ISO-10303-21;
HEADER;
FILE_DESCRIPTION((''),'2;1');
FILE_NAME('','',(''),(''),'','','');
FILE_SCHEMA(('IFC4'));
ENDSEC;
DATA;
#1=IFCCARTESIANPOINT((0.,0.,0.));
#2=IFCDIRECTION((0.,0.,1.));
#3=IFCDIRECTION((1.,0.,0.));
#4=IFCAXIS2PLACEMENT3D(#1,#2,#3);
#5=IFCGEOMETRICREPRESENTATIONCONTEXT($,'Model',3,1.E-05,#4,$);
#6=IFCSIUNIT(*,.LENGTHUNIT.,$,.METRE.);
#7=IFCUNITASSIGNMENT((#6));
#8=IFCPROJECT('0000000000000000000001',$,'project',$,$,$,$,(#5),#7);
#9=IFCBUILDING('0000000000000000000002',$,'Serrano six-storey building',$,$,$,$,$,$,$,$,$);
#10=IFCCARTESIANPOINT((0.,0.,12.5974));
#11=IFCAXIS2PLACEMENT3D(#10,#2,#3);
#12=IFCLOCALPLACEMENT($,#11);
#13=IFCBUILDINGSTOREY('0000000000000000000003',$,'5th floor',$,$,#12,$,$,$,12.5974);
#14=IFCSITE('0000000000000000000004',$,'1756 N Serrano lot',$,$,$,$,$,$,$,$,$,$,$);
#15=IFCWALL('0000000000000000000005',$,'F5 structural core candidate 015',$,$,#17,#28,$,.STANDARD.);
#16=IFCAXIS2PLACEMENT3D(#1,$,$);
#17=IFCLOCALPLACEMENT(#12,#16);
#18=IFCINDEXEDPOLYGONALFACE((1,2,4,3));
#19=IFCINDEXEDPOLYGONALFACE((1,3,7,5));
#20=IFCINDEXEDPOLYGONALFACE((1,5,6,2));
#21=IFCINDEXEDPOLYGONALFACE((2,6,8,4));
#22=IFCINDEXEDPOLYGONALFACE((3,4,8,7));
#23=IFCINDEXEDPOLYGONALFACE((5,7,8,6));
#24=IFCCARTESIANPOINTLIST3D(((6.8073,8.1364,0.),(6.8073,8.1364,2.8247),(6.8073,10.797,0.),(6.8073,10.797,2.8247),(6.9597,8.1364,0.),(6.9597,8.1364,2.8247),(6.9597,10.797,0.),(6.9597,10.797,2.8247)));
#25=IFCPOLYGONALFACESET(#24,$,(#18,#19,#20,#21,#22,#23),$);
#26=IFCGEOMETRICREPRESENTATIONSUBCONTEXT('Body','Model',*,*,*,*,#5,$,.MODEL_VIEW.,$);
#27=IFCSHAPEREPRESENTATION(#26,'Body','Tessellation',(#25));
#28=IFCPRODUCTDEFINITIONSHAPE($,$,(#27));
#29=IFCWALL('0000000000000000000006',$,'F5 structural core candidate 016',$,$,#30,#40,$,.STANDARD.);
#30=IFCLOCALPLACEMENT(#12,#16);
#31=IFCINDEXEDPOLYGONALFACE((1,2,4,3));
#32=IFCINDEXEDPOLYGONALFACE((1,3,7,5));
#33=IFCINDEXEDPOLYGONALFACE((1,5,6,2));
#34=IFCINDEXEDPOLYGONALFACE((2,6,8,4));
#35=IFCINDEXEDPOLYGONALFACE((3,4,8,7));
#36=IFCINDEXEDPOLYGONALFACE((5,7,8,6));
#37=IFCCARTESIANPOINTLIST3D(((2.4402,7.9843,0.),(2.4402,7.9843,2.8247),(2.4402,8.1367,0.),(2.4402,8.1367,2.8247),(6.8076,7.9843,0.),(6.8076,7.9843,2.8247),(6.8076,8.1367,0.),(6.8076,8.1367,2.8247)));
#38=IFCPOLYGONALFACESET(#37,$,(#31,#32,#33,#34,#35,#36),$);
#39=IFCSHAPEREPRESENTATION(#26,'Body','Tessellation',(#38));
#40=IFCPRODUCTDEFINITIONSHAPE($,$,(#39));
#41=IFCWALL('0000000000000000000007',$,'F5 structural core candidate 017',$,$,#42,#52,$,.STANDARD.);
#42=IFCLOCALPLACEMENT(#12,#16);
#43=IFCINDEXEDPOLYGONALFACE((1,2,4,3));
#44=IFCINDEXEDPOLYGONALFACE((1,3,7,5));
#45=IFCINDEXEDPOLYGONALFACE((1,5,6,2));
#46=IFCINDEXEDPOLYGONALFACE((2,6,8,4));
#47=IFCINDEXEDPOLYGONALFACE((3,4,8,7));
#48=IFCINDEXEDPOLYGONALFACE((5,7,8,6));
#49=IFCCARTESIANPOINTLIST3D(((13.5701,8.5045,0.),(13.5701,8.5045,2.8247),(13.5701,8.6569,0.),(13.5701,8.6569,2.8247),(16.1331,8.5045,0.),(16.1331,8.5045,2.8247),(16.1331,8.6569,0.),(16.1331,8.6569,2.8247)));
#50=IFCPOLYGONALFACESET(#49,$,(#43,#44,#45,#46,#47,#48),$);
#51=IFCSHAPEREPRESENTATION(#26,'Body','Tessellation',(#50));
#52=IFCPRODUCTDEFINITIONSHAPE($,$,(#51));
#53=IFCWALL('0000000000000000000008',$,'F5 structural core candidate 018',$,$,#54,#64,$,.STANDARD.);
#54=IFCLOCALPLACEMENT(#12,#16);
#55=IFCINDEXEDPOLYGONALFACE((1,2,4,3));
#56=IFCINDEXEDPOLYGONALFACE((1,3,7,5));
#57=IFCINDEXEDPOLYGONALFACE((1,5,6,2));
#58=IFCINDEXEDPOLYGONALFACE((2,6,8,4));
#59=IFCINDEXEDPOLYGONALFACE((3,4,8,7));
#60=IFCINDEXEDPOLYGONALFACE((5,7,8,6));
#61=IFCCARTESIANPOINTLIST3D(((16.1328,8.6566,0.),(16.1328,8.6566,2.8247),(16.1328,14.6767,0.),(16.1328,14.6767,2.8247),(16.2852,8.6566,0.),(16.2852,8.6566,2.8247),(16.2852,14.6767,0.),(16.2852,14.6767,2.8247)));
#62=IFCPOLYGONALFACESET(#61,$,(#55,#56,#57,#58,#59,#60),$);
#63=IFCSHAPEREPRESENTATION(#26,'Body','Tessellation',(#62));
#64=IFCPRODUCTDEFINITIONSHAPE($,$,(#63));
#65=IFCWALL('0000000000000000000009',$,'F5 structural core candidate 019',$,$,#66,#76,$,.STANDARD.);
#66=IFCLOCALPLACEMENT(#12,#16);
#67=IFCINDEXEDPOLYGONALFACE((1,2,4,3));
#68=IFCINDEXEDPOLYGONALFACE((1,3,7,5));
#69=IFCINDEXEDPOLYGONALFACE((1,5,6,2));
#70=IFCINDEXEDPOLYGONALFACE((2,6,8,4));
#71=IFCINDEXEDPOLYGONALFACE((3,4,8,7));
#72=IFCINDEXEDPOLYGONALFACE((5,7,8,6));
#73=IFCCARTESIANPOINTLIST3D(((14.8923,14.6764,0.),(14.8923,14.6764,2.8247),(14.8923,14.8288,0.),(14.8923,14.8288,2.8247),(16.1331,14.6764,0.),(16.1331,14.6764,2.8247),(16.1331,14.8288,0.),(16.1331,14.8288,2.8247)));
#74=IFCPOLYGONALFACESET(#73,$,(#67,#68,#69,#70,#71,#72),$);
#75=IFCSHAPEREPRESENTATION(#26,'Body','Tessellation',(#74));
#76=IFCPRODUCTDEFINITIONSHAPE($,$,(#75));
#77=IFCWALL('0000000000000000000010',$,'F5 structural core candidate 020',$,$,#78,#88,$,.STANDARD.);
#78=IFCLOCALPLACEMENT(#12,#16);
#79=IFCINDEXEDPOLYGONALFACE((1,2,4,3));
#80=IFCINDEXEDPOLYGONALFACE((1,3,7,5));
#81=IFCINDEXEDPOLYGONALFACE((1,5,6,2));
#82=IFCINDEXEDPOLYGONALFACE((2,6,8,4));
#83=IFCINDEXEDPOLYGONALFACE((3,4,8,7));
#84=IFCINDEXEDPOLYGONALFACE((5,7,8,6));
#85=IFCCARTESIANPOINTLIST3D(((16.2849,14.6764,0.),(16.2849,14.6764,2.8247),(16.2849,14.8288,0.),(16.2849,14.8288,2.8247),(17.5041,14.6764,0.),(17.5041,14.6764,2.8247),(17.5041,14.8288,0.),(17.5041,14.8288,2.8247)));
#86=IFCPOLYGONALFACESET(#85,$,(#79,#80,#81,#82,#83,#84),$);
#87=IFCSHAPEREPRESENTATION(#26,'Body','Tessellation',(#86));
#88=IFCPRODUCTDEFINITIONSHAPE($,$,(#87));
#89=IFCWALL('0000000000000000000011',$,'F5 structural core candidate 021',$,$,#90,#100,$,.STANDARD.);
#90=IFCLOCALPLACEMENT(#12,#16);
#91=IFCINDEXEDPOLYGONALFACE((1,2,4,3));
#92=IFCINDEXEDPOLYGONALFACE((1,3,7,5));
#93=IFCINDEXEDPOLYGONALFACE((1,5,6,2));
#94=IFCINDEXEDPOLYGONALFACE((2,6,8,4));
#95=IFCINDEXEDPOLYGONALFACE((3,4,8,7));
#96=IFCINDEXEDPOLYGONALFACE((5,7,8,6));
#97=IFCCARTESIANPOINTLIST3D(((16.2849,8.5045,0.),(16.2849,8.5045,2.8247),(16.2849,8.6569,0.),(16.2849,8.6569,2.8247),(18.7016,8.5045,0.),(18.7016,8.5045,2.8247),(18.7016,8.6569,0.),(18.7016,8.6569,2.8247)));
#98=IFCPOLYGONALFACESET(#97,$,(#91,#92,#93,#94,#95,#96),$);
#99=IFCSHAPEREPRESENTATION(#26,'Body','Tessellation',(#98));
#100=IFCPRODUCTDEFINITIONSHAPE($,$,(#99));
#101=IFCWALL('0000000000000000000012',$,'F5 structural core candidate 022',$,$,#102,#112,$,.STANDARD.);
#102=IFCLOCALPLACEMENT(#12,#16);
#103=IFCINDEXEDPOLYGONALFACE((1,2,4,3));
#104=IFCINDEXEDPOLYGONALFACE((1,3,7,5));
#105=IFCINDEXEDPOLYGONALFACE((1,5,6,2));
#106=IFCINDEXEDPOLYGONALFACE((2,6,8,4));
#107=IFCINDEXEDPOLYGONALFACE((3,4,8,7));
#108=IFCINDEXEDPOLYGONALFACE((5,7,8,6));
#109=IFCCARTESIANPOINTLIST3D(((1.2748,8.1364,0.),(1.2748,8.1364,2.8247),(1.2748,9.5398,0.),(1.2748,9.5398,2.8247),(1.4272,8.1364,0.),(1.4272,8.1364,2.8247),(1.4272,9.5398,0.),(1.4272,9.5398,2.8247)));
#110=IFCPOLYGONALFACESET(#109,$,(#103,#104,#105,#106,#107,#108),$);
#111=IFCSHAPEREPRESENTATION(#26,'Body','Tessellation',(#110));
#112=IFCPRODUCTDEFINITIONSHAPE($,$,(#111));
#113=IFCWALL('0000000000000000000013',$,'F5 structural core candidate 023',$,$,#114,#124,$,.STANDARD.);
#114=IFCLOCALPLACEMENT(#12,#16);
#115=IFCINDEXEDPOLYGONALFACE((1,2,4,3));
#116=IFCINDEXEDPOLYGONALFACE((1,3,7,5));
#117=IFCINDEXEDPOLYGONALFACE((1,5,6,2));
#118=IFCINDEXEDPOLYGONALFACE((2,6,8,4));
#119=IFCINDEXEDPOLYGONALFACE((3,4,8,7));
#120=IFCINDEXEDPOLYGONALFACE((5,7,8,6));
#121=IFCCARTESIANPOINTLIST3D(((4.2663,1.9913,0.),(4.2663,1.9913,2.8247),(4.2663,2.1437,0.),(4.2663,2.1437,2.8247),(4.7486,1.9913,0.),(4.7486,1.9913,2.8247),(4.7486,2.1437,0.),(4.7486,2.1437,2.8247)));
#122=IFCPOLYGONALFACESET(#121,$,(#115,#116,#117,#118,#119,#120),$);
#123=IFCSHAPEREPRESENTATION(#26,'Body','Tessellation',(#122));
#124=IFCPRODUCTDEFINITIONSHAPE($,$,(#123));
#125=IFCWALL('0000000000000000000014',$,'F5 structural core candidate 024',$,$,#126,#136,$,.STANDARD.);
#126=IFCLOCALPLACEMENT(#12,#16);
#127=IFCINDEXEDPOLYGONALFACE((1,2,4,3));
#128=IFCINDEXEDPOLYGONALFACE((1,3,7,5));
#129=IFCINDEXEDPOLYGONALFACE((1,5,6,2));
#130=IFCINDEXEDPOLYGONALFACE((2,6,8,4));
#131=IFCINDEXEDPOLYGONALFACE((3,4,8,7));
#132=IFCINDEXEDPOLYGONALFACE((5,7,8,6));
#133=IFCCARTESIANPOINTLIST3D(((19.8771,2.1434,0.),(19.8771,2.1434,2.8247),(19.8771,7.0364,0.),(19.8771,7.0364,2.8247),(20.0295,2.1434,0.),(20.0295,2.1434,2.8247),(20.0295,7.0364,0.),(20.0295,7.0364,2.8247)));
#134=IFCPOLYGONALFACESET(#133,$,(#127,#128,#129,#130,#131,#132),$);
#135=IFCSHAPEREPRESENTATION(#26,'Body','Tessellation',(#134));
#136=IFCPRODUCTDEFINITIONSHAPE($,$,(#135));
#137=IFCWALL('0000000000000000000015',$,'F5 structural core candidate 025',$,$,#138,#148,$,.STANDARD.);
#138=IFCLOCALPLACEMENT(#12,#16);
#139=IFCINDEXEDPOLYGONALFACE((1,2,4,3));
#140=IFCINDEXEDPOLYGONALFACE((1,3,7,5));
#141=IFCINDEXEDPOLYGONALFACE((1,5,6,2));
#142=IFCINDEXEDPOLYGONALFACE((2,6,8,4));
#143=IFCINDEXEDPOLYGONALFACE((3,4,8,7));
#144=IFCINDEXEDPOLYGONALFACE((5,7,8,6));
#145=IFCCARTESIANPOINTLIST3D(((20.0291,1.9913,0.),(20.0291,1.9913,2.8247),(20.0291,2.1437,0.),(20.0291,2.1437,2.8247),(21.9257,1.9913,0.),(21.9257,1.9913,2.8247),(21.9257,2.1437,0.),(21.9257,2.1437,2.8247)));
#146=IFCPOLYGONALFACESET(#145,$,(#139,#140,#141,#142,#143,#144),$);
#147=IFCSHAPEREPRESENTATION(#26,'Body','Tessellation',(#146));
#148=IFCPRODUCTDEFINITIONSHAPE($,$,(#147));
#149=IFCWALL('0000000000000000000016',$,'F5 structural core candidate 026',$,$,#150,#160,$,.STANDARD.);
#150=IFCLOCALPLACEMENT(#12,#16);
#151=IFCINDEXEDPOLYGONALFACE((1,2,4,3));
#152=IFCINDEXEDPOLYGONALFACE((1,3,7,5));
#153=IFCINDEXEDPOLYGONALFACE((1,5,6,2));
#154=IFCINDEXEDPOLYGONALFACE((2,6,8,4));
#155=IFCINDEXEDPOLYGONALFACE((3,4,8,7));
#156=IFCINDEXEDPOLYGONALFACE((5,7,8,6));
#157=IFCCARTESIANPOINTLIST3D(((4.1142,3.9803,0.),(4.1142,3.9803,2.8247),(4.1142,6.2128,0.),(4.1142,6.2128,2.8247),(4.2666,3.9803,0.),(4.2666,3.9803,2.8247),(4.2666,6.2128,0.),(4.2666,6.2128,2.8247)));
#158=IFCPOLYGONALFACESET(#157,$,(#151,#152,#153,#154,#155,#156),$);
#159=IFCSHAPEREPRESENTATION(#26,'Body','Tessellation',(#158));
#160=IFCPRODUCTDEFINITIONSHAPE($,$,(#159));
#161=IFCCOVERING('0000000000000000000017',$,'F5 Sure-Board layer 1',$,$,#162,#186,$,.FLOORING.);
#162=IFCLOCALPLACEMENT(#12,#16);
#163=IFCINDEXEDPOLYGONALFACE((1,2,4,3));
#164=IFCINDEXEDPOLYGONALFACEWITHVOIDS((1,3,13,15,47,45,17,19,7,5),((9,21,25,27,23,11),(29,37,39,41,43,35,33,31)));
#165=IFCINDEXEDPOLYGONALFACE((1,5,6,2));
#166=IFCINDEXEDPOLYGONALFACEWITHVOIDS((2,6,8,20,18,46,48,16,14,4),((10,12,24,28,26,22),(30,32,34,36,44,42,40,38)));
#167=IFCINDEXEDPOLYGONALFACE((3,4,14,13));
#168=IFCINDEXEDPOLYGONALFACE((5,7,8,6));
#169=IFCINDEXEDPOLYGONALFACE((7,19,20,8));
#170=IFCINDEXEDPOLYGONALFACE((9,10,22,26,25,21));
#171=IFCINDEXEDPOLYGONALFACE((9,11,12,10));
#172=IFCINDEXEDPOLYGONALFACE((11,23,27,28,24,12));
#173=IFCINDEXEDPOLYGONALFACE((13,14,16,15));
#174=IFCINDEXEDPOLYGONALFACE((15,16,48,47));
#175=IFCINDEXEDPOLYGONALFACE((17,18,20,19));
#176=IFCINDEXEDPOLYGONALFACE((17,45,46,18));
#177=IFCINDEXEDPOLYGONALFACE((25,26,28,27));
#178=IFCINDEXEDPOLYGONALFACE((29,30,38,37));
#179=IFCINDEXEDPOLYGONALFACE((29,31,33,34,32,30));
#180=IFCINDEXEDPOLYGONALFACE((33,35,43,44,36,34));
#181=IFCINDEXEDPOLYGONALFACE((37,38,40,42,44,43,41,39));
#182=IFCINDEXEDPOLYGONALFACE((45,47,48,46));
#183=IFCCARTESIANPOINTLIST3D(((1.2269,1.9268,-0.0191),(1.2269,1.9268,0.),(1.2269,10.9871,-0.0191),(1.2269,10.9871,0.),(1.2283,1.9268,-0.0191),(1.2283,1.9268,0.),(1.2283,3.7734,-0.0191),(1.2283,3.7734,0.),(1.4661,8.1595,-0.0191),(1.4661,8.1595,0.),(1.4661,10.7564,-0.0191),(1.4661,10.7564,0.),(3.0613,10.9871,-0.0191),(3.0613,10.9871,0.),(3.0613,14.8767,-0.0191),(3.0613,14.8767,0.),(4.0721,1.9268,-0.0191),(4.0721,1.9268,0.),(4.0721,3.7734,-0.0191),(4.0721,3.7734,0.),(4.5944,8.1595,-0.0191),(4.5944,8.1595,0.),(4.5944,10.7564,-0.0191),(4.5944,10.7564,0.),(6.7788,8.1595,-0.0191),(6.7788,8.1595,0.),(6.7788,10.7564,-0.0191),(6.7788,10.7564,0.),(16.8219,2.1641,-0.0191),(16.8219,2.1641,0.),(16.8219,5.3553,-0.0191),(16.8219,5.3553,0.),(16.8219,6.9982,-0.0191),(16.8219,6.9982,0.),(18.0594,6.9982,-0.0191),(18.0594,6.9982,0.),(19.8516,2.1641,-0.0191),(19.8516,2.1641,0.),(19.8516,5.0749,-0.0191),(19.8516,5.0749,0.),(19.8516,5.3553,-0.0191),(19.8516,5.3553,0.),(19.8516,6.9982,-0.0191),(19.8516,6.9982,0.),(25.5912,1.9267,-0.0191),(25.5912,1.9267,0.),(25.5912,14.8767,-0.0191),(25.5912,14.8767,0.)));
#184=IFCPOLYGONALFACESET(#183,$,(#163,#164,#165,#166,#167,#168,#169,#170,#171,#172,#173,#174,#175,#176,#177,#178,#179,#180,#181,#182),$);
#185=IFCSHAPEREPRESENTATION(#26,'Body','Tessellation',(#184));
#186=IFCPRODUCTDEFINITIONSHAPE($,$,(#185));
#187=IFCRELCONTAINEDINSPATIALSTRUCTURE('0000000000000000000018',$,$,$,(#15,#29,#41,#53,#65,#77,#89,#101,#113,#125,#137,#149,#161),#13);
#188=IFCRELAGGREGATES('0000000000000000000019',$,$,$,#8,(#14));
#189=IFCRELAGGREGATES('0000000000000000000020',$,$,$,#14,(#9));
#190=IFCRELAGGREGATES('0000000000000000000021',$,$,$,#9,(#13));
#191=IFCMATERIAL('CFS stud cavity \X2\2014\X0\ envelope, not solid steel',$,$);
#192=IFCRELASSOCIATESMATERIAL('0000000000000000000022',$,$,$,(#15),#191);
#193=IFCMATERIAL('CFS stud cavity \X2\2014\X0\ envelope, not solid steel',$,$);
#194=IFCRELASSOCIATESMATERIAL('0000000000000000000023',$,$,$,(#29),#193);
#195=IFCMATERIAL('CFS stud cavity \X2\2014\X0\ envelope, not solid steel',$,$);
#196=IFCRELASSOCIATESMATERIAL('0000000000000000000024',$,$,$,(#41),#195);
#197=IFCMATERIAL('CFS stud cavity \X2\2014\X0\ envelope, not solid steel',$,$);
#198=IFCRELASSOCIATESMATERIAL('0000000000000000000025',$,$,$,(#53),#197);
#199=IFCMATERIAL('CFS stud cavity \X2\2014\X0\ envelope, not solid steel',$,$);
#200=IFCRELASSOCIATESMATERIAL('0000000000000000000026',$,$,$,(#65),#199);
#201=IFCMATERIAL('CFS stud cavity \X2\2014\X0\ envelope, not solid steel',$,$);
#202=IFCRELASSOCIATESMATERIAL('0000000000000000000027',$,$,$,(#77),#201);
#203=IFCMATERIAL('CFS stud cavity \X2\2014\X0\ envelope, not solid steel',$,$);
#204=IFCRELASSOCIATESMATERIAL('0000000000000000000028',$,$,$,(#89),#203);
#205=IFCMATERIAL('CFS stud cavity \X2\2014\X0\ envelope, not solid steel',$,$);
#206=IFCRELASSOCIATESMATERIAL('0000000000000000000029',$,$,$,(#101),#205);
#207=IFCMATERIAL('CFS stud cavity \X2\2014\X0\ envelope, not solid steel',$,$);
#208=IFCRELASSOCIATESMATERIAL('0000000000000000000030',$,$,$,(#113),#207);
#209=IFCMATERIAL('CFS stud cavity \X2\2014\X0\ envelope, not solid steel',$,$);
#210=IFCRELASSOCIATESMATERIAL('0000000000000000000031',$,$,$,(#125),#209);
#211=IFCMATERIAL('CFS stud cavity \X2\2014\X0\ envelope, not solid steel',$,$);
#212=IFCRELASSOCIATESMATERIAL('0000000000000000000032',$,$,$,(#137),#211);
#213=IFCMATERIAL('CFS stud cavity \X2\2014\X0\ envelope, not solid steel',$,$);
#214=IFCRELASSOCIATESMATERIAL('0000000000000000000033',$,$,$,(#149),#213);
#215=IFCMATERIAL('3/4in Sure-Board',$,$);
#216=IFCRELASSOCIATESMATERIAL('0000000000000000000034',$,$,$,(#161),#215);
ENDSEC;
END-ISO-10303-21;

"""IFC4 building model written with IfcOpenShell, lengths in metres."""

from ifc_helpers import new_model, si_unit, frame, origin_with_axes, place, context, subcontext, project, spatial, polyline, outline, extrude, material, element, save


model = new_model("IFC4")

# Units and contexts
model_context = context("Model", 3, precision=1e-05, world=origin_with_axes())
body_context = subcontext(model_context, "Body", "Model", "MODEL_VIEW")
ifc_project = project(units=[si_unit("LENGTHUNIT", "METRE")], contexts=[model_context])

# Site, building, storey
site = spatial("IfcSite", under=ifc_project, Name="1756 N Serrano lot")
building = spatial("IfcBuilding", under=site, Name="Serrano six-storey building")
storey_placement = place(None, frame((0.0, 0.0, 12.5974), z_axis=(0.0, 0.0, 1.0), x_axis=(1.0, 0.0, 0.0)))
storey = spatial("IfcBuildingStorey", under=building, at=storey_placement, Name="5th floor", Elevation=12.5974)

# Walls
ifc_material_1 = material(Name="CFS stud cavity — envelope, not solid steel")
wall_1_placement = place(storey_placement, frame((0.0, 0.0, -12.5974), z_axis=(0.0, 0.0, 1.0), x_axis=(1.0, 0.0, 0.0)))
element("IfcWall", 1, at=wall_1_placement, inside=storey, material=ifc_material_1, Name="F5 structural core candidate 015", PredefinedType="STANDARD", context=body_context, shape_type="SweptSolid", body=[
    extrude(outline(polyline([(6.9597, 8.1364), (6.8073, 8.1364), (6.8073, 10.797), (6.9597, 10.797), (6.9597, 8.1364)])), frame((0.0, 0.0, 12.5974)), (0.0, 0.0, 1.0), 2.8247),
])
ifc_material_2 = material(Name="CFS stud cavity — envelope, not solid steel")
wall_2_placement = place(storey_placement, frame((0.0, 0.0, -12.5974), z_axis=(0.0, 0.0, 1.0), x_axis=(1.0, 0.0, 0.0)))
element("IfcWall", 2, at=wall_2_placement, inside=storey, material=ifc_material_2, Name="F5 structural core candidate 016", PredefinedType="STANDARD", context=body_context, shape_type="SweptSolid", body=[
    extrude(outline(polyline([(6.8076, 8.1367), (6.8076, 7.9843), (2.4402, 7.9843), (2.4402, 8.1367), (6.8076, 8.1367)])), frame((0.0, 0.0, 12.5974)), (0.0, 0.0, 1.0), 2.8247),
])
ifc_material_3 = material(Name="CFS stud cavity — envelope, not solid steel")
wall_3_placement = place(storey_placement, frame((0.0, 0.0, -12.5974), z_axis=(0.0, 0.0, 1.0), x_axis=(1.0, 0.0, 0.0)))
element("IfcWall", 3, at=wall_3_placement, inside=storey, material=ifc_material_3, Name="F5 structural core candidate 017", PredefinedType="STANDARD", context=body_context, shape_type="SweptSolid", body=[
    extrude(outline(polyline([(16.1331, 8.6569), (16.1331, 8.5045), (13.5701, 8.5045), (13.5701, 8.6569), (16.1331, 8.6569)])), frame((0.0, 0.0, 12.5974)), (0.0, 0.0, 1.0), 2.8247),
])
ifc_material_4 = material(Name="CFS stud cavity — envelope, not solid steel")
wall_4_placement = place(storey_placement, frame((0.0, 0.0, -12.5974), z_axis=(0.0, 0.0, 1.0), x_axis=(1.0, 0.0, 0.0)))
element("IfcWall", 4, at=wall_4_placement, inside=storey, material=ifc_material_4, Name="F5 structural core candidate 018", PredefinedType="STANDARD", context=body_context, shape_type="SweptSolid", body=[
    extrude(outline(polyline([(16.2852, 8.6566), (16.1328, 8.6566), (16.1328, 14.6767), (16.2852, 14.6767), (16.2852, 8.6566)])), frame((0.0, 0.0, 12.5974)), (0.0, 0.0, 1.0), 2.8247),
])
ifc_material_5 = material(Name="CFS stud cavity — envelope, not solid steel")
wall_5_placement = place(storey_placement, frame((0.0, 0.0, -12.5974), z_axis=(0.0, 0.0, 1.0), x_axis=(1.0, 0.0, 0.0)))
element("IfcWall", 5, at=wall_5_placement, inside=storey, material=ifc_material_5, Name="F5 structural core candidate 019", PredefinedType="STANDARD", context=body_context, shape_type="SweptSolid", body=[
    extrude(outline(polyline([(16.1331, 14.8288), (16.1331, 14.6764), (14.8923, 14.6764), (14.8923, 14.8288), (16.1331, 14.8288)])), frame((0.0, 0.0, 12.5974)), (0.0, 0.0, 1.0), 2.8247),
])
ifc_material_6 = material(Name="CFS stud cavity — envelope, not solid steel")
wall_6_placement = place(storey_placement, frame((0.0, 0.0, -12.5974), z_axis=(0.0, 0.0, 1.0), x_axis=(1.0, 0.0, 0.0)))
element("IfcWall", 6, at=wall_6_placement, inside=storey, material=ifc_material_6, Name="F5 structural core candidate 020", PredefinedType="STANDARD", context=body_context, shape_type="SweptSolid", body=[
    extrude(outline(polyline([(17.5041, 14.8288), (17.5041, 14.6764), (16.2849, 14.6764), (16.2849, 14.8288), (17.5041, 14.8288)])), frame((0.0, 0.0, 12.5974)), (0.0, 0.0, 1.0), 2.8247),
])
ifc_material_7 = material(Name="CFS stud cavity — envelope, not solid steel")
wall_7_placement = place(storey_placement, frame((0.0, 0.0, -12.5974), z_axis=(0.0, 0.0, 1.0), x_axis=(1.0, 0.0, 0.0)))
element("IfcWall", 7, at=wall_7_placement, inside=storey, material=ifc_material_7, Name="F5 structural core candidate 021", PredefinedType="STANDARD", context=body_context, shape_type="SweptSolid", body=[
    extrude(outline(polyline([(18.7016, 8.6569), (18.7016, 8.5045), (16.2849, 8.5045), (16.2849, 8.6569), (18.7016, 8.6569)])), frame((0.0, 0.0, 12.5974)), (0.0, 0.0, 1.0), 2.8247),
])
ifc_material_8 = material(Name="CFS stud cavity — envelope, not solid steel")
wall_8_placement = place(storey_placement, frame((0.0, 0.0, -12.5974), z_axis=(0.0, 0.0, 1.0), x_axis=(1.0, 0.0, 0.0)))
element("IfcWall", 8, at=wall_8_placement, inside=storey, material=ifc_material_8, Name="F5 structural core candidate 022", PredefinedType="STANDARD", context=body_context, shape_type="SweptSolid", body=[
    extrude(outline(polyline([(1.4272, 8.1364), (1.2748, 8.1364), (1.2748, 9.5398), (1.4272, 9.5398), (1.4272, 8.1364)])), frame((0.0, 0.0, 12.5974)), (0.0, 0.0, 1.0), 2.8247),
])
ifc_material_9 = material(Name="CFS stud cavity — envelope, not solid steel")
wall_9_placement = place(storey_placement, frame((0.0, 0.0, -12.5974), z_axis=(0.0, 0.0, 1.0), x_axis=(1.0, 0.0, 0.0)))
element("IfcWall", 9, at=wall_9_placement, inside=storey, material=ifc_material_9, Name="F5 structural core candidate 023", PredefinedType="STANDARD", context=body_context, shape_type="SweptSolid", body=[
    extrude(outline(polyline([(4.7486, 2.1437), (4.7486, 1.9913), (4.2663, 1.9913), (4.2663, 2.1437), (4.7486, 2.1437)])), frame((0.0, 0.0, 12.5974)), (0.0, 0.0, 1.0), 2.8247),
])
ifc_material_10 = material(Name="CFS stud cavity — envelope, not solid steel")
wall_10_placement = place(storey_placement, frame((0.0, 0.0, -12.5974), z_axis=(0.0, 0.0, 1.0), x_axis=(1.0, 0.0, 0.0)))
element("IfcWall", 10, at=wall_10_placement, inside=storey, material=ifc_material_10, Name="F5 structural core candidate 024", PredefinedType="STANDARD", context=body_context, shape_type="SweptSolid", body=[
    extrude(outline(polyline([(20.0295, 2.1434), (19.8771, 2.1434), (19.8771, 7.0364), (20.0295, 7.0364), (20.0295, 2.1434)])), frame((0.0, 0.0, 12.5974)), (0.0, 0.0, 1.0), 2.8247),
])
ifc_material_11 = material(Name="CFS stud cavity — envelope, not solid steel")
wall_11_placement = place(storey_placement, frame((0.0, 0.0, -12.5974), z_axis=(0.0, 0.0, 1.0), x_axis=(1.0, 0.0, 0.0)))
element("IfcWall", 11, at=wall_11_placement, inside=storey, material=ifc_material_11, Name="F5 structural core candidate 025", PredefinedType="STANDARD", context=body_context, shape_type="SweptSolid", body=[
    extrude(outline(polyline([(21.9257, 2.1437), (21.9257, 1.9913), (20.0291, 1.9913), (20.0291, 2.1437), (21.9257, 2.1437)])), frame((0.0, 0.0, 12.5974)), (0.0, 0.0, 1.0), 2.8247),
])
ifc_material_12 = material(Name="CFS stud cavity — envelope, not solid steel")
wall_12_placement = place(storey_placement, frame((0.0, 0.0, -12.5974), z_axis=(0.0, 0.0, 1.0), x_axis=(1.0, 0.0, 0.0)))
element("IfcWall", 12, at=wall_12_placement, inside=storey, material=ifc_material_12, Name="F5 structural core candidate 026", PredefinedType="STANDARD", context=body_context, shape_type="SweptSolid", body=[
    extrude(outline(polyline([(4.2666, 3.9803), (4.1142, 3.9803), (4.1142, 6.2128), (4.2666, 6.2128), (4.2666, 3.9803)])), frame((0.0, 0.0, 12.5974)), (0.0, 0.0, 1.0), 2.8247),
])

# Covering
ifc_material_13 = material(Name="3/4in Sure-Board")
covering_placement = place(storey_placement, frame((0.0, 0.0, -12.5974), z_axis=(0.0, 0.0, 1.0), x_axis=(1.0, 0.0, 0.0)))
element("IfcCovering", 13, at=covering_placement, inside=storey, material=ifc_material_13, Name="F5 Sure-Board layer 1", PredefinedType="FLOORING", context=body_context, shape_type="SweptSolid", body=[
    extrude(outline(polyline([(3.0613, 14.8767), (25.5912, 14.8767), (25.5912, 1.9267), (4.0721, 1.9268), (4.0721, 3.7734), (1.2283, 3.7734), (1.2283, 1.9268), (1.2269, 1.9268), (1.2269, 10.9871), (3.0613, 10.9871), (3.0613, 14.8767)]), holes=[polyline([(6.7788, 10.7564), (4.5944, 10.7564), (1.4661, 10.7564), (1.4661, 8.1595), (4.5944, 8.1595), (6.7788, 8.1595), (6.7788, 10.7564)]), polyline([(16.8219, 5.3553), (16.8219, 2.1641), (19.8516, 2.1641), (19.8516, 5.0749), (19.8516, 5.3553), (19.8516, 6.9982), (18.0594, 6.9982), (16.8219, 6.9982), (16.8219, 5.3553)])]), frame((0.0, 0.0, 12.5783)), (0.0, 0.0, 1.0), 0.0191),
])

save(model, "model.ifc")
